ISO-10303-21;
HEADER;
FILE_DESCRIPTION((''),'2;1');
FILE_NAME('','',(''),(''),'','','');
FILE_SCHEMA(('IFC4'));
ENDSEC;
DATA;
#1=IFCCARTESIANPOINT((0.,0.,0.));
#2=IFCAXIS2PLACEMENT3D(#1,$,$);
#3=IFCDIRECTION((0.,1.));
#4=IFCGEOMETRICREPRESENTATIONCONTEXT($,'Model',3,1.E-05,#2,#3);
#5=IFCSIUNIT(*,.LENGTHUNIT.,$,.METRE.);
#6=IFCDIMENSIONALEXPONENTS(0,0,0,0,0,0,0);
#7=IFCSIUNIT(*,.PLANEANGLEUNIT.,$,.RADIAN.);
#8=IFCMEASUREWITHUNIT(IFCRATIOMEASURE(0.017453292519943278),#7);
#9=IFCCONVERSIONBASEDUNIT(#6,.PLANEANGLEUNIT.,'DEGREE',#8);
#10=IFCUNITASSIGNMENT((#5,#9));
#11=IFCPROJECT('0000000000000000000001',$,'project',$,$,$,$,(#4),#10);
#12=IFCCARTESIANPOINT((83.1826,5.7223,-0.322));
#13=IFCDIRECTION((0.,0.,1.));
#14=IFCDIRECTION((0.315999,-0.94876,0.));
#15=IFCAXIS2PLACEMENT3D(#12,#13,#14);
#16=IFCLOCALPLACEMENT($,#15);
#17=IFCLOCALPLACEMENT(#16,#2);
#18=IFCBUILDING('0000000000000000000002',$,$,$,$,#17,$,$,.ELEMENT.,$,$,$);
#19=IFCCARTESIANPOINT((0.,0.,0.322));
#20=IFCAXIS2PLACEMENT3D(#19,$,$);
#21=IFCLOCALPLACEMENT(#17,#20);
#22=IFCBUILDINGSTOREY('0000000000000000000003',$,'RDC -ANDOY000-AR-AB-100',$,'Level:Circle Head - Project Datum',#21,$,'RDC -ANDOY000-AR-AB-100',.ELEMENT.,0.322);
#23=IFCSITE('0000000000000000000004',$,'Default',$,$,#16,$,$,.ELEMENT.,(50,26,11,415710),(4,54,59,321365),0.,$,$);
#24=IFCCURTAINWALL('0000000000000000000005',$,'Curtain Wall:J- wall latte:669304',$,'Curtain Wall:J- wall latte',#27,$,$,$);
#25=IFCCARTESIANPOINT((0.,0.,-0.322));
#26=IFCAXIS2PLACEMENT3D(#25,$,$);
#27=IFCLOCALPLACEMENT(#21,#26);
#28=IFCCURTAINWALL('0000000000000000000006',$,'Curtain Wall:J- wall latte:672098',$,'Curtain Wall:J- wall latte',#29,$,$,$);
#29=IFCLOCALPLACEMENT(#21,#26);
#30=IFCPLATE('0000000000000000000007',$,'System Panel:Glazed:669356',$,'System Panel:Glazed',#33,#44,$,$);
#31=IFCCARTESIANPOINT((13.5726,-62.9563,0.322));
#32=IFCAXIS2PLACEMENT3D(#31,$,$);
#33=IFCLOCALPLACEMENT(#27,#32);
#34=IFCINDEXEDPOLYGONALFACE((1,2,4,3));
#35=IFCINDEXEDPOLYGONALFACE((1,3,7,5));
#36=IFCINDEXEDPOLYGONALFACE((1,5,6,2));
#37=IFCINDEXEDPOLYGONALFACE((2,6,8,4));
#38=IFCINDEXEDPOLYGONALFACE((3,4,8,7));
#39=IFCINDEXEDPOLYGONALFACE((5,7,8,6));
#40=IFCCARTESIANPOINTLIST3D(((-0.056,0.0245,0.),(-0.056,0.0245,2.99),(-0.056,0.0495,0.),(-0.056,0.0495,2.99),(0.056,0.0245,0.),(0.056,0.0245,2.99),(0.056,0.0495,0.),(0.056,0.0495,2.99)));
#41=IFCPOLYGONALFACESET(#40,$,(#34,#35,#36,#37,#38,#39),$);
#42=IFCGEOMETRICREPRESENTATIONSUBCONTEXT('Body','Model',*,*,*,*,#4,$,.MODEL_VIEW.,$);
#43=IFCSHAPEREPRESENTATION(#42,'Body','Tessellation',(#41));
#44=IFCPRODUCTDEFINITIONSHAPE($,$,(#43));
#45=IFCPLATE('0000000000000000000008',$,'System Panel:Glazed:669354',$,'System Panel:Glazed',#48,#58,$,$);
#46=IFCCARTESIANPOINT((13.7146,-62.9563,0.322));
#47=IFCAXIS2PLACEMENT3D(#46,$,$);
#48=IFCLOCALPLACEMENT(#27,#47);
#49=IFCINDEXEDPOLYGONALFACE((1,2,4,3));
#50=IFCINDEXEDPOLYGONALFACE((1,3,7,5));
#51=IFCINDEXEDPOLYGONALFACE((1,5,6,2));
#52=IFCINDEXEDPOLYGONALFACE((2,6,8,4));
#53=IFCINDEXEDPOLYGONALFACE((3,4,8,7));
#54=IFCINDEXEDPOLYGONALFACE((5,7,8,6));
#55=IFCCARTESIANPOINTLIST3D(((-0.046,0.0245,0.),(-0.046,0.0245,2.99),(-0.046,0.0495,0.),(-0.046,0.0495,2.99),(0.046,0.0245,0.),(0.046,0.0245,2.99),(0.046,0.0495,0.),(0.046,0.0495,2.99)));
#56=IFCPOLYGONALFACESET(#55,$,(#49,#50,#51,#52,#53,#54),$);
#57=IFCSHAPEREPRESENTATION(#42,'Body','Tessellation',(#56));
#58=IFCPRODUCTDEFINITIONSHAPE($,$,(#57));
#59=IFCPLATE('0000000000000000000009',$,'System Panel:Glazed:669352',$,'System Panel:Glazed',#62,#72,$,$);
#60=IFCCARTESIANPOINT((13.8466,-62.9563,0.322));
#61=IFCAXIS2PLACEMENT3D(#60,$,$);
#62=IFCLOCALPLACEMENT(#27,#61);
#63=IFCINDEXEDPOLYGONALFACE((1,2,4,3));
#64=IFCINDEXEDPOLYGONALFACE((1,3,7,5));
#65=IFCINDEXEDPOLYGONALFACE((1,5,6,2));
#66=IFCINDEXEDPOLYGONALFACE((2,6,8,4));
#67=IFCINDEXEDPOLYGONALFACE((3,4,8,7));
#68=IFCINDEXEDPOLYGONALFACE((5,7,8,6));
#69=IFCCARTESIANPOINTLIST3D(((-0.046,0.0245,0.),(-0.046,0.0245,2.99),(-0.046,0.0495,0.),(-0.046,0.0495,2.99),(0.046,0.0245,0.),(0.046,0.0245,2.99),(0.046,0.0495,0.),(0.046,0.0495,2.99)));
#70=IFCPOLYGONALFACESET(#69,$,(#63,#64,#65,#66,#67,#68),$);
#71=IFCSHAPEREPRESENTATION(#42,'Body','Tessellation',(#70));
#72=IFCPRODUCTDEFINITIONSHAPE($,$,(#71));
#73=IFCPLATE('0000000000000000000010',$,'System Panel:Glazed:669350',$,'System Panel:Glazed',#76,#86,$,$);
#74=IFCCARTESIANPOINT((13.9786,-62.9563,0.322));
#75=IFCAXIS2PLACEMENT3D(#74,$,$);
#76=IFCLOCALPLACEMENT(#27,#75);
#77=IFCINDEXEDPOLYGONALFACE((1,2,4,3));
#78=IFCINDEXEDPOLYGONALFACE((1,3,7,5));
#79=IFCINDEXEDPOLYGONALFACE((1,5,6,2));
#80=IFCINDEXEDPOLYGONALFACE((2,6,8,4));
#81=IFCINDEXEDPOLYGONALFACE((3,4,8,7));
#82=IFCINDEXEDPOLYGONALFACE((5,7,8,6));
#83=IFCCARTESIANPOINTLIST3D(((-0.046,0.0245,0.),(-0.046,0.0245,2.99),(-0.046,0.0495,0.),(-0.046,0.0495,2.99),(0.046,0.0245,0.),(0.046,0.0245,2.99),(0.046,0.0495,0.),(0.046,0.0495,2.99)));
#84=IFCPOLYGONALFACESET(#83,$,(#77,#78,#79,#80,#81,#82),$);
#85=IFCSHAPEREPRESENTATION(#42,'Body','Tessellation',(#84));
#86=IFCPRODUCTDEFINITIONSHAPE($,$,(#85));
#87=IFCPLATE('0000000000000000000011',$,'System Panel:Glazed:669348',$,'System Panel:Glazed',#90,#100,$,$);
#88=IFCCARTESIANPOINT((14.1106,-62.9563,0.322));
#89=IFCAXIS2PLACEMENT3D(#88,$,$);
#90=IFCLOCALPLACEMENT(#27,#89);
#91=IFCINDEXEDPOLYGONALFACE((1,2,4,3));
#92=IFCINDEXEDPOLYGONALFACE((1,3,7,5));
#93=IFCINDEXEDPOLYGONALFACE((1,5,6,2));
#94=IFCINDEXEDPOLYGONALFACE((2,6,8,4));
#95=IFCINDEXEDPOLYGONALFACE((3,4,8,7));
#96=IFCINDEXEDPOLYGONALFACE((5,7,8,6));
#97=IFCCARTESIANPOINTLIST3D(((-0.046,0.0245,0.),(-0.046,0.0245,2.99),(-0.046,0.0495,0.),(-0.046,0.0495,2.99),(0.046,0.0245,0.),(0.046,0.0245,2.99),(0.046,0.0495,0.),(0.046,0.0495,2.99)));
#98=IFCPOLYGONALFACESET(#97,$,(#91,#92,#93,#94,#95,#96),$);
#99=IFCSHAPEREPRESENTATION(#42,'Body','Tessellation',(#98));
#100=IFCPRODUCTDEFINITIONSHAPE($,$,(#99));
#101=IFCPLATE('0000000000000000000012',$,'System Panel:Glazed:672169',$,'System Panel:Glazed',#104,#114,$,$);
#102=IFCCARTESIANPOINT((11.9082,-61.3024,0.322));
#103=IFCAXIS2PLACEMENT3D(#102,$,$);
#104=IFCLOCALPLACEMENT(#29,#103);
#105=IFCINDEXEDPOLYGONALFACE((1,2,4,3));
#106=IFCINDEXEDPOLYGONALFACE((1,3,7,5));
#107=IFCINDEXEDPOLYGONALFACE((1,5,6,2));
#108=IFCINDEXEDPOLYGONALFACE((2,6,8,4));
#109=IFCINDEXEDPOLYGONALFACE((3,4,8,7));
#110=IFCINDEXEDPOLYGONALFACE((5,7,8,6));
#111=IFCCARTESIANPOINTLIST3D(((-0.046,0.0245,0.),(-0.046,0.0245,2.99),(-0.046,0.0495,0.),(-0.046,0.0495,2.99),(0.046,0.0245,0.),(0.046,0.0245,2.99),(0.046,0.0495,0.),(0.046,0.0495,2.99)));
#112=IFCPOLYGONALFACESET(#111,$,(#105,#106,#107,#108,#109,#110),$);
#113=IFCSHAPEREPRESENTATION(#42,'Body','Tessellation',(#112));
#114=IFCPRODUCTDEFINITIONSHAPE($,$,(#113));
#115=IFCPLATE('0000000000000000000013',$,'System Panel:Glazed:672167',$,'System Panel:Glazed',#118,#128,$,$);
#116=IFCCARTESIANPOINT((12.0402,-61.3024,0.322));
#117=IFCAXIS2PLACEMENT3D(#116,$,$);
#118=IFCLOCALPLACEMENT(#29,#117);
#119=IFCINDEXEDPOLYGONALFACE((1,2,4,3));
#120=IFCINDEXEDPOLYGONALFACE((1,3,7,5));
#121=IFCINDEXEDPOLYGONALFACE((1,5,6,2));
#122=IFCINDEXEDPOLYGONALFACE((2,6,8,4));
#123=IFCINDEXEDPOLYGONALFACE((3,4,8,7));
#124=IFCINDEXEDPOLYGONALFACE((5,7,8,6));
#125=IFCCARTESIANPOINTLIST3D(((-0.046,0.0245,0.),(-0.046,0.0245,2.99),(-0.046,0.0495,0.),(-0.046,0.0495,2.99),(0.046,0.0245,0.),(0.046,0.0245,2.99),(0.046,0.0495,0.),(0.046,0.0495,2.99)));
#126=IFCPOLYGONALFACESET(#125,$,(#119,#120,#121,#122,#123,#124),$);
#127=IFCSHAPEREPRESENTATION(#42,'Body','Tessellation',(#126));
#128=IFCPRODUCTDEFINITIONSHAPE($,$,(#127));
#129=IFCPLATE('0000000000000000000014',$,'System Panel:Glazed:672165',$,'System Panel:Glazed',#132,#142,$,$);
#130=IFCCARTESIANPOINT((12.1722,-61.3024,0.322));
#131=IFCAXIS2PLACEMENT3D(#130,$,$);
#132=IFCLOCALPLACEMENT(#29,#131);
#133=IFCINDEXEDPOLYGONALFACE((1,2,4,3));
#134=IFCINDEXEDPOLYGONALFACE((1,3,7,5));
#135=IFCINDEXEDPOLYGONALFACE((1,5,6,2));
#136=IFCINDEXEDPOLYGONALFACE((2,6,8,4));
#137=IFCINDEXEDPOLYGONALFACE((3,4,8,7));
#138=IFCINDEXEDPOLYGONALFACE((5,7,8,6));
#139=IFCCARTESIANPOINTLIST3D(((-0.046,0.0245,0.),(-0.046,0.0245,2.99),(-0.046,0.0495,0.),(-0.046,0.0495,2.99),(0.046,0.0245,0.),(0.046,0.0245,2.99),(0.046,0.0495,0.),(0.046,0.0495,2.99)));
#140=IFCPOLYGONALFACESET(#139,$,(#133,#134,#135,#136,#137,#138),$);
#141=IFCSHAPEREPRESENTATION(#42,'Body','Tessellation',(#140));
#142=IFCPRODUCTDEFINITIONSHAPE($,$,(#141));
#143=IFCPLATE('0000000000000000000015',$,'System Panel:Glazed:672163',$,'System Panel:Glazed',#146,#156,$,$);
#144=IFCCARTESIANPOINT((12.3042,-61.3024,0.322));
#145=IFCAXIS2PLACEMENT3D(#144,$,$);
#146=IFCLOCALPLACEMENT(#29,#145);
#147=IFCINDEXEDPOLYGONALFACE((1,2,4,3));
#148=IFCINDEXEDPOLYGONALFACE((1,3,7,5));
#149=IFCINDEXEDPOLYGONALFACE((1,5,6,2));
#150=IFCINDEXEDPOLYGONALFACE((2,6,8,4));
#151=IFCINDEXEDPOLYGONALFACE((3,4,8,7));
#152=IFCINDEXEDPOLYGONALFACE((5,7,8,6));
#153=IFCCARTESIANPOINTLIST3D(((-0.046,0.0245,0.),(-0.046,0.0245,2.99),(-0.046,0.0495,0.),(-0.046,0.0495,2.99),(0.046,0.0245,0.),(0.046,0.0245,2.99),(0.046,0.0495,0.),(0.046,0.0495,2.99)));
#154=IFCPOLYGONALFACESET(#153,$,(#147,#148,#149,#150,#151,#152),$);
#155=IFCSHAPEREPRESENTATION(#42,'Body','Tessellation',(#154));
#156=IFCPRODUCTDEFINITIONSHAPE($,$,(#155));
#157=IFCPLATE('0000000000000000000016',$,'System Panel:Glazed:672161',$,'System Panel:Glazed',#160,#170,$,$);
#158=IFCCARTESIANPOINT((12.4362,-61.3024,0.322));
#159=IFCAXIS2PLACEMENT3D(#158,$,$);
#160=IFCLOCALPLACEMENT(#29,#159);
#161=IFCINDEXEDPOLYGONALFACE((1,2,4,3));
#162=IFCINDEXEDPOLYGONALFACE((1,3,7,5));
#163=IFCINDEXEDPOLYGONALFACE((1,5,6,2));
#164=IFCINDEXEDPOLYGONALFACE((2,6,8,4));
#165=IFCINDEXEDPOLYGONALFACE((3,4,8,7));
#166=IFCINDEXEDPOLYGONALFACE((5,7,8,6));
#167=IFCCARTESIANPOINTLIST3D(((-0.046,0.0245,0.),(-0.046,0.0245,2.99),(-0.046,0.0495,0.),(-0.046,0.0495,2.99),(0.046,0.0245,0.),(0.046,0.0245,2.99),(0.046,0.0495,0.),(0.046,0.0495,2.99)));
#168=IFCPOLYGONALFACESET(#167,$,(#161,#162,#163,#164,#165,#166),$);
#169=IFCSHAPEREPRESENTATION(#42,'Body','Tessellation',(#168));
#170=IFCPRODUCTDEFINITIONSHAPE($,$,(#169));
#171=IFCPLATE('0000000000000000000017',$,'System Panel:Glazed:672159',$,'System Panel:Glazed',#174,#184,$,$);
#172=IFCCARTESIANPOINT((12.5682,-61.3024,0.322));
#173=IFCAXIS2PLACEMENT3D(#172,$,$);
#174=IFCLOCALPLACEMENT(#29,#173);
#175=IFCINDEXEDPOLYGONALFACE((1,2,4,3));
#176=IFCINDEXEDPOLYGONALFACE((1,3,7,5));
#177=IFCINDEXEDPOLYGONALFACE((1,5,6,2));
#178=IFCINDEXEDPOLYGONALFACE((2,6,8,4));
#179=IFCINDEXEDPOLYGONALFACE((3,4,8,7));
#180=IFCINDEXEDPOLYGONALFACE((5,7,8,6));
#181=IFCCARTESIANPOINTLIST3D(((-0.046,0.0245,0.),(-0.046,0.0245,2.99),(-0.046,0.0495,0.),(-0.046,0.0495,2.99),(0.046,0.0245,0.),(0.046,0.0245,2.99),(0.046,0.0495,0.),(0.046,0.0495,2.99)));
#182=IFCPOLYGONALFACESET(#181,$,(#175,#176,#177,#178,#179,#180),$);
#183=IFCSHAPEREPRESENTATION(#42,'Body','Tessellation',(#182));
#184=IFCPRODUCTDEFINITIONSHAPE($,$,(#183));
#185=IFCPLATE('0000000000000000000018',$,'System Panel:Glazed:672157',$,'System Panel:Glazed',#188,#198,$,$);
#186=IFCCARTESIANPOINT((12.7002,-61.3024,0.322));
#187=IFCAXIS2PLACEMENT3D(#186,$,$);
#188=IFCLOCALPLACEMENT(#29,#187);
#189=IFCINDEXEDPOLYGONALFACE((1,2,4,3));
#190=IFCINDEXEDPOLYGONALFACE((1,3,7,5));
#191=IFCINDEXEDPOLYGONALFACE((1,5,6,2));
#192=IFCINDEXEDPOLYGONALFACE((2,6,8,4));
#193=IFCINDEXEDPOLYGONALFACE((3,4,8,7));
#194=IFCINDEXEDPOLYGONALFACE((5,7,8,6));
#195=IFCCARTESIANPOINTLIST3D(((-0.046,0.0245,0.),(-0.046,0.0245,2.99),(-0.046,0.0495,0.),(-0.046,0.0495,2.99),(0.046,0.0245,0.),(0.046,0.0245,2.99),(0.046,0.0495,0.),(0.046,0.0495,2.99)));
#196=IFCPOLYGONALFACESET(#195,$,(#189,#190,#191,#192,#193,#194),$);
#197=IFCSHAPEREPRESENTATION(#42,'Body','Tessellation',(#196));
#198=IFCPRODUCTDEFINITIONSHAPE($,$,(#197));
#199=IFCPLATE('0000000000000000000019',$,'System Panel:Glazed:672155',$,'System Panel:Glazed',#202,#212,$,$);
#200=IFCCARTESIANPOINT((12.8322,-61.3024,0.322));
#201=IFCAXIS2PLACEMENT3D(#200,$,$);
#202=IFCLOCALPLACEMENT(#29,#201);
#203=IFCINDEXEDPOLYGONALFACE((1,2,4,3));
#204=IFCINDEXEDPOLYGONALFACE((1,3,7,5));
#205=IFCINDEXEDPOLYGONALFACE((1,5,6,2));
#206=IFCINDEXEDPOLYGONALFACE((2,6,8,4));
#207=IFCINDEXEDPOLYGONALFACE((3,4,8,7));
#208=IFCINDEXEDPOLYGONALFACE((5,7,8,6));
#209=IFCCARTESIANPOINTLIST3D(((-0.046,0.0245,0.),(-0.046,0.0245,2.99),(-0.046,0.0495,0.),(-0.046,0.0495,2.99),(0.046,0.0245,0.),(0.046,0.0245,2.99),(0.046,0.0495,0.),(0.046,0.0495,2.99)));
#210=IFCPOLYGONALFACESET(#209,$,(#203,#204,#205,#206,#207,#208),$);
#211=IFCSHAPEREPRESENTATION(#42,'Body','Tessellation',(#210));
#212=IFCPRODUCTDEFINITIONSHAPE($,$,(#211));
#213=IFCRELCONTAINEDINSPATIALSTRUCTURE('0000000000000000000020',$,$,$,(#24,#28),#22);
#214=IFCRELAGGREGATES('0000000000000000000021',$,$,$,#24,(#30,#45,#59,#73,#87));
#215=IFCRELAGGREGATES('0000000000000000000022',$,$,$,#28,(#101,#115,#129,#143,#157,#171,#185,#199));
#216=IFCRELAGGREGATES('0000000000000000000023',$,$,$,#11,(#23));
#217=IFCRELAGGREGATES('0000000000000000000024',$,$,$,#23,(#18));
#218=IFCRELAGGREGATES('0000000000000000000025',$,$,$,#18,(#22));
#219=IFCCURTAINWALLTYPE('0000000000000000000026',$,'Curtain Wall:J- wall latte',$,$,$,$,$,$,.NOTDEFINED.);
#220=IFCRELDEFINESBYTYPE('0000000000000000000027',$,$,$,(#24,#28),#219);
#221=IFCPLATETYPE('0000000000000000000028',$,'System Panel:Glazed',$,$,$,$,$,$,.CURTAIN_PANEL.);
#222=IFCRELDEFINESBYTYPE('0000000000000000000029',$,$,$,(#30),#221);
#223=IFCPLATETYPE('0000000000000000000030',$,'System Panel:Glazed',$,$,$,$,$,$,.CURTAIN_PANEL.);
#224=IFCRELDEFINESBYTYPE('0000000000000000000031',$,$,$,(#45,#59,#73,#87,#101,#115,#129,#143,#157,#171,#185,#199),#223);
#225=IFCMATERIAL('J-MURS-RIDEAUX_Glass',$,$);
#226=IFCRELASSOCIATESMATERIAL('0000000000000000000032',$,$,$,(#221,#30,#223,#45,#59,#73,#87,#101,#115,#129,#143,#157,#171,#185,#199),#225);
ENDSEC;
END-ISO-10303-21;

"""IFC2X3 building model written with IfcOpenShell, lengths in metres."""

from ifc_helpers import new_model, entity, si_unit, converted_unit, direction, frame, frame_2d, origin, place, context, subcontext, project, spatial, rectangle, extrude, source, transform, mapped, material, type_object, type_shapes, element, aggregate, save


model = new_model("IFC2X3")

# Units and contexts
model_context = context("Model", 3, precision=1e-05, world=origin(), true_north=direction((0.0, 1.0)))
body_context = subcontext(model_context, "Body", "Model", "MODEL_VIEW")
ifc_project = project(units=[si_unit("LENGTHUNIT", "METRE"), converted_unit("PLANEANGLEUNIT", "DEGREE", entity("IfcRatioMeasure", 0.017453292519943278), si_unit("PLANEANGLEUNIT", "RADIAN"), dimensions=[0, 0, 0, 0, 0, 0, 0])], contexts=[model_context])

# Site, building, storey
site_placement = place(None, frame((83.1826, 5.7223, -0.322), z_axis=(0.0, 0.0, 1.0), x_axis=(0.315999, -0.94876, 0.0)))
site = spatial("IfcSite", under=ifc_project, at=site_placement, Name="Default", CompositionType="ELEMENT", RefLatitude=(50, 26, 11, 415710), RefLongitude=(4, 54, 59, 321365), RefElevation=0.0)
building_placement = place(site_placement, origin())
building = spatial("IfcBuilding", under=site, at=building_placement, CompositionType="ELEMENT")
storey_placement = place(building_placement, frame((0.0, 0.0, 0.322)))
storey = spatial("IfcBuildingStorey", under=building, at=storey_placement, Name="RDC -ANDOY000-AR-AB-100", ObjectType="Level:Circle Head - Project Datum", LongName="RDC -ANDOY000-AR-AB-100", CompositionType="ELEMENT", Elevation=0.322)

# Curtain walls
curtain_wall_type = type_object("IfcCurtainWallType", Name="Curtain Wall:J- wall latte", PredefinedType="NOTDEFINED")
curtain_wall_1_placement = place(storey_placement, frame((0.0, 0.0, -0.322)))
curtain_wall_1 = element("IfcCurtainWall", 1, at=curtain_wall_1_placement, inside=storey, type_object=curtain_wall_type, Name="Curtain Wall:J- wall latte:669304", ObjectType="Curtain Wall:J- wall latte")
curtain_wall_2_placement = place(storey_placement, frame((0.0, 0.0, -0.322)))
curtain_wall_2 = element("IfcCurtainWall", 2, at=curtain_wall_2_placement, inside=storey, type_object=curtain_wall_type, Name="Curtain Wall:J- wall latte:672098", ObjectType="Curtain Wall:J- wall latte")

# Plates
ifc_material_1 = material(Name="J-MURS-RIDEAUX_Glass")
plate_type_1 = type_object("IfcPlateType", Name="System Panel:Glazed", PredefinedType="CURTAIN_PANEL", material=ifc_material_1)
shared_shape_1 = source(origin(), body_context, "Body", "SweptSolid", [
    extrude(rectangle(XDim=0.025, YDim=0.112, at=frame_2d((0.0, 0.0), x_axis=(1.0, 0.0))), frame((0.0, 0.037, 0.0), z_axis=(0.0, 0.0, 1.0), x_axis=(0.0, 1.0, 0.0)), (0.0, 0.0, 1.0), 2.99),
])
type_shapes(plate_type_1, [shared_shape_1])
plate_1_placement = place(curtain_wall_1_placement, frame((13.5726, -62.9563, 0.322)))
plate_1 = element("IfcPlate", 3, at=plate_1_placement, type_object=plate_type_1, material=ifc_material_1, Name="System Panel:Glazed:669356", ObjectType="System Panel:Glazed", context=body_context, shape_type="MappedRepresentation", body=[
    mapped(shared_shape_1, transform((0.0, 0.0, 0.0), scale=1.0)),
])
plate_type_2 = type_object("IfcPlateType", Name="System Panel:Glazed", PredefinedType="CURTAIN_PANEL", material=ifc_material_1)
shared_shape_2 = source(origin(), body_context, "Body", "SweptSolid", [
    extrude(rectangle(XDim=0.025, YDim=0.092, at=frame_2d((0.0, 0.0), x_axis=(1.0, 0.0))), frame((0.0, 0.037, 0.0), z_axis=(0.0, 0.0, 1.0), x_axis=(0.0, 1.0, 0.0)), (0.0, 0.0, 1.0), 2.99),
])
type_shapes(plate_type_2, [shared_shape_2])
plate_2_placement = place(curtain_wall_1_placement, frame((13.7146, -62.9563, 0.322)))
plate_2 = element("IfcPlate", 4, at=plate_2_placement, type_object=plate_type_2, material=ifc_material_1, Name="System Panel:Glazed:669354", ObjectType="System Panel:Glazed", context=body_context, shape_type="MappedRepresentation", body=[
    mapped(shared_shape_2, transform((0.0, 0.0, 0.0), scale=1.0)),
])
plate_3_placement = place(curtain_wall_1_placement, frame((13.8466, -62.9563, 0.322)))
plate_3 = element("IfcPlate", 5, at=plate_3_placement, type_object=plate_type_2, material=ifc_material_1, Name="System Panel:Glazed:669352", ObjectType="System Panel:Glazed", context=body_context, shape_type="MappedRepresentation", body=[
    mapped(shared_shape_2, transform((0.0, 0.0, 0.0), scale=1.0)),
])
plate_4_placement = place(curtain_wall_1_placement, frame((13.9786, -62.9563, 0.322)))
plate_4 = element("IfcPlate", 6, at=plate_4_placement, type_object=plate_type_2, material=ifc_material_1, Name="System Panel:Glazed:669350", ObjectType="System Panel:Glazed", context=body_context, shape_type="MappedRepresentation", body=[
    mapped(shared_shape_2, transform((0.0, 0.0, 0.0), scale=1.0)),
])
plate_5_placement = place(curtain_wall_1_placement, frame((14.1106, -62.9563, 0.322)))
plate_5 = element("IfcPlate", 7, at=plate_5_placement, type_object=plate_type_2, material=ifc_material_1, Name="System Panel:Glazed:669348", ObjectType="System Panel:Glazed", context=body_context, shape_type="MappedRepresentation", body=[
    mapped(shared_shape_2, transform((0.0, 0.0, 0.0), scale=1.0)),
])
aggregate(curtain_wall_1, [plate_1, plate_2, plate_3, plate_4, plate_5])
plate_6_placement = place(curtain_wall_2_placement, frame((11.9082, -61.3024, 0.322)))
plate_6 = element("IfcPlate", 8, at=plate_6_placement, type_object=plate_type_2, material=ifc_material_1, Name="System Panel:Glazed:672169", ObjectType="System Panel:Glazed", context=body_context, shape_type="MappedRepresentation", body=[
    mapped(shared_shape_2, transform((0.0, 0.0, 0.0), scale=1.0)),
])
plate_7_placement = place(curtain_wall_2_placement, frame((12.0402, -61.3024, 0.322)))
plate_7 = element("IfcPlate", 9, at=plate_7_placement, type_object=plate_type_2, material=ifc_material_1, Name="System Panel:Glazed:672167", ObjectType="System Panel:Glazed", context=body_context, shape_type="MappedRepresentation", body=[
    mapped(shared_shape_2, transform((0.0, 0.0, 0.0), scale=1.0)),
])
plate_8_placement = place(curtain_wall_2_placement, frame((12.1722, -61.3024, 0.322)))
plate_8 = element("IfcPlate", 10, at=plate_8_placement, type_object=plate_type_2, material=ifc_material_1, Name="System Panel:Glazed:672165", ObjectType="System Panel:Glazed", context=body_context, shape_type="MappedRepresentation", body=[
    mapped(shared_shape_2, transform((0.0, 0.0, 0.0), scale=1.0)),
])
plate_9_placement = place(curtain_wall_2_placement, frame((12.3042, -61.3024, 0.322)))
plate_9 = element("IfcPlate", 11, at=plate_9_placement, type_object=plate_type_2, material=ifc_material_1, Name="System Panel:Glazed:672163", ObjectType="System Panel:Glazed", context=body_context, shape_type="MappedRepresentation", body=[
    mapped(shared_shape_2, transform((0.0, 0.0, 0.0), scale=1.0)),
])
plate_10_placement = place(curtain_wall_2_placement, frame((12.4362, -61.3024, 0.322)))
plate_10 = element("IfcPlate", 12, at=plate_10_placement, type_object=plate_type_2, material=ifc_material_1, Name="System Panel:Glazed:672161", ObjectType="System Panel:Glazed", context=body_context, shape_type="MappedRepresentation", body=[
    mapped(shared_shape_2, transform((0.0, 0.0, 0.0), scale=1.0)),
])
plate_11_placement = place(curtain_wall_2_placement, frame((12.5682, -61.3024, 0.322)))
plate_11 = element("IfcPlate", 13, at=plate_11_placement, type_object=plate_type_2, material=ifc_material_1, Name="System Panel:Glazed:672159", ObjectType="System Panel:Glazed", context=body_context, shape_type="MappedRepresentation", body=[
    mapped(shared_shape_2, transform((0.0, 0.0, 0.0), scale=1.0)),
])
plate_12_placement = place(curtain_wall_2_placement, frame((12.7002, -61.3024, 0.322)))
plate_12 = element("IfcPlate", 14, at=plate_12_placement, type_object=plate_type_2, material=ifc_material_1, Name="System Panel:Glazed:672157", ObjectType="System Panel:Glazed", context=body_context, shape_type="MappedRepresentation", body=[
    mapped(shared_shape_2, transform((0.0, 0.0, 0.0), scale=1.0)),
])
plate_13_placement = place(curtain_wall_2_placement, frame((12.8322, -61.3024, 0.322)))
plate_13 = element("IfcPlate", 15, at=plate_13_placement, type_object=plate_type_2, material=ifc_material_1, Name="System Panel:Glazed:672155", ObjectType="System Panel:Glazed", context=body_context, shape_type="MappedRepresentation", body=[
    mapped(shared_shape_2, transform((0.0, 0.0, 0.0), scale=1.0)),
])
aggregate(curtain_wall_2, [plate_6, plate_7, plate_8, plate_9, plate_10, plate_11, plate_12, plate_13])

save(model, "model.ifc")
